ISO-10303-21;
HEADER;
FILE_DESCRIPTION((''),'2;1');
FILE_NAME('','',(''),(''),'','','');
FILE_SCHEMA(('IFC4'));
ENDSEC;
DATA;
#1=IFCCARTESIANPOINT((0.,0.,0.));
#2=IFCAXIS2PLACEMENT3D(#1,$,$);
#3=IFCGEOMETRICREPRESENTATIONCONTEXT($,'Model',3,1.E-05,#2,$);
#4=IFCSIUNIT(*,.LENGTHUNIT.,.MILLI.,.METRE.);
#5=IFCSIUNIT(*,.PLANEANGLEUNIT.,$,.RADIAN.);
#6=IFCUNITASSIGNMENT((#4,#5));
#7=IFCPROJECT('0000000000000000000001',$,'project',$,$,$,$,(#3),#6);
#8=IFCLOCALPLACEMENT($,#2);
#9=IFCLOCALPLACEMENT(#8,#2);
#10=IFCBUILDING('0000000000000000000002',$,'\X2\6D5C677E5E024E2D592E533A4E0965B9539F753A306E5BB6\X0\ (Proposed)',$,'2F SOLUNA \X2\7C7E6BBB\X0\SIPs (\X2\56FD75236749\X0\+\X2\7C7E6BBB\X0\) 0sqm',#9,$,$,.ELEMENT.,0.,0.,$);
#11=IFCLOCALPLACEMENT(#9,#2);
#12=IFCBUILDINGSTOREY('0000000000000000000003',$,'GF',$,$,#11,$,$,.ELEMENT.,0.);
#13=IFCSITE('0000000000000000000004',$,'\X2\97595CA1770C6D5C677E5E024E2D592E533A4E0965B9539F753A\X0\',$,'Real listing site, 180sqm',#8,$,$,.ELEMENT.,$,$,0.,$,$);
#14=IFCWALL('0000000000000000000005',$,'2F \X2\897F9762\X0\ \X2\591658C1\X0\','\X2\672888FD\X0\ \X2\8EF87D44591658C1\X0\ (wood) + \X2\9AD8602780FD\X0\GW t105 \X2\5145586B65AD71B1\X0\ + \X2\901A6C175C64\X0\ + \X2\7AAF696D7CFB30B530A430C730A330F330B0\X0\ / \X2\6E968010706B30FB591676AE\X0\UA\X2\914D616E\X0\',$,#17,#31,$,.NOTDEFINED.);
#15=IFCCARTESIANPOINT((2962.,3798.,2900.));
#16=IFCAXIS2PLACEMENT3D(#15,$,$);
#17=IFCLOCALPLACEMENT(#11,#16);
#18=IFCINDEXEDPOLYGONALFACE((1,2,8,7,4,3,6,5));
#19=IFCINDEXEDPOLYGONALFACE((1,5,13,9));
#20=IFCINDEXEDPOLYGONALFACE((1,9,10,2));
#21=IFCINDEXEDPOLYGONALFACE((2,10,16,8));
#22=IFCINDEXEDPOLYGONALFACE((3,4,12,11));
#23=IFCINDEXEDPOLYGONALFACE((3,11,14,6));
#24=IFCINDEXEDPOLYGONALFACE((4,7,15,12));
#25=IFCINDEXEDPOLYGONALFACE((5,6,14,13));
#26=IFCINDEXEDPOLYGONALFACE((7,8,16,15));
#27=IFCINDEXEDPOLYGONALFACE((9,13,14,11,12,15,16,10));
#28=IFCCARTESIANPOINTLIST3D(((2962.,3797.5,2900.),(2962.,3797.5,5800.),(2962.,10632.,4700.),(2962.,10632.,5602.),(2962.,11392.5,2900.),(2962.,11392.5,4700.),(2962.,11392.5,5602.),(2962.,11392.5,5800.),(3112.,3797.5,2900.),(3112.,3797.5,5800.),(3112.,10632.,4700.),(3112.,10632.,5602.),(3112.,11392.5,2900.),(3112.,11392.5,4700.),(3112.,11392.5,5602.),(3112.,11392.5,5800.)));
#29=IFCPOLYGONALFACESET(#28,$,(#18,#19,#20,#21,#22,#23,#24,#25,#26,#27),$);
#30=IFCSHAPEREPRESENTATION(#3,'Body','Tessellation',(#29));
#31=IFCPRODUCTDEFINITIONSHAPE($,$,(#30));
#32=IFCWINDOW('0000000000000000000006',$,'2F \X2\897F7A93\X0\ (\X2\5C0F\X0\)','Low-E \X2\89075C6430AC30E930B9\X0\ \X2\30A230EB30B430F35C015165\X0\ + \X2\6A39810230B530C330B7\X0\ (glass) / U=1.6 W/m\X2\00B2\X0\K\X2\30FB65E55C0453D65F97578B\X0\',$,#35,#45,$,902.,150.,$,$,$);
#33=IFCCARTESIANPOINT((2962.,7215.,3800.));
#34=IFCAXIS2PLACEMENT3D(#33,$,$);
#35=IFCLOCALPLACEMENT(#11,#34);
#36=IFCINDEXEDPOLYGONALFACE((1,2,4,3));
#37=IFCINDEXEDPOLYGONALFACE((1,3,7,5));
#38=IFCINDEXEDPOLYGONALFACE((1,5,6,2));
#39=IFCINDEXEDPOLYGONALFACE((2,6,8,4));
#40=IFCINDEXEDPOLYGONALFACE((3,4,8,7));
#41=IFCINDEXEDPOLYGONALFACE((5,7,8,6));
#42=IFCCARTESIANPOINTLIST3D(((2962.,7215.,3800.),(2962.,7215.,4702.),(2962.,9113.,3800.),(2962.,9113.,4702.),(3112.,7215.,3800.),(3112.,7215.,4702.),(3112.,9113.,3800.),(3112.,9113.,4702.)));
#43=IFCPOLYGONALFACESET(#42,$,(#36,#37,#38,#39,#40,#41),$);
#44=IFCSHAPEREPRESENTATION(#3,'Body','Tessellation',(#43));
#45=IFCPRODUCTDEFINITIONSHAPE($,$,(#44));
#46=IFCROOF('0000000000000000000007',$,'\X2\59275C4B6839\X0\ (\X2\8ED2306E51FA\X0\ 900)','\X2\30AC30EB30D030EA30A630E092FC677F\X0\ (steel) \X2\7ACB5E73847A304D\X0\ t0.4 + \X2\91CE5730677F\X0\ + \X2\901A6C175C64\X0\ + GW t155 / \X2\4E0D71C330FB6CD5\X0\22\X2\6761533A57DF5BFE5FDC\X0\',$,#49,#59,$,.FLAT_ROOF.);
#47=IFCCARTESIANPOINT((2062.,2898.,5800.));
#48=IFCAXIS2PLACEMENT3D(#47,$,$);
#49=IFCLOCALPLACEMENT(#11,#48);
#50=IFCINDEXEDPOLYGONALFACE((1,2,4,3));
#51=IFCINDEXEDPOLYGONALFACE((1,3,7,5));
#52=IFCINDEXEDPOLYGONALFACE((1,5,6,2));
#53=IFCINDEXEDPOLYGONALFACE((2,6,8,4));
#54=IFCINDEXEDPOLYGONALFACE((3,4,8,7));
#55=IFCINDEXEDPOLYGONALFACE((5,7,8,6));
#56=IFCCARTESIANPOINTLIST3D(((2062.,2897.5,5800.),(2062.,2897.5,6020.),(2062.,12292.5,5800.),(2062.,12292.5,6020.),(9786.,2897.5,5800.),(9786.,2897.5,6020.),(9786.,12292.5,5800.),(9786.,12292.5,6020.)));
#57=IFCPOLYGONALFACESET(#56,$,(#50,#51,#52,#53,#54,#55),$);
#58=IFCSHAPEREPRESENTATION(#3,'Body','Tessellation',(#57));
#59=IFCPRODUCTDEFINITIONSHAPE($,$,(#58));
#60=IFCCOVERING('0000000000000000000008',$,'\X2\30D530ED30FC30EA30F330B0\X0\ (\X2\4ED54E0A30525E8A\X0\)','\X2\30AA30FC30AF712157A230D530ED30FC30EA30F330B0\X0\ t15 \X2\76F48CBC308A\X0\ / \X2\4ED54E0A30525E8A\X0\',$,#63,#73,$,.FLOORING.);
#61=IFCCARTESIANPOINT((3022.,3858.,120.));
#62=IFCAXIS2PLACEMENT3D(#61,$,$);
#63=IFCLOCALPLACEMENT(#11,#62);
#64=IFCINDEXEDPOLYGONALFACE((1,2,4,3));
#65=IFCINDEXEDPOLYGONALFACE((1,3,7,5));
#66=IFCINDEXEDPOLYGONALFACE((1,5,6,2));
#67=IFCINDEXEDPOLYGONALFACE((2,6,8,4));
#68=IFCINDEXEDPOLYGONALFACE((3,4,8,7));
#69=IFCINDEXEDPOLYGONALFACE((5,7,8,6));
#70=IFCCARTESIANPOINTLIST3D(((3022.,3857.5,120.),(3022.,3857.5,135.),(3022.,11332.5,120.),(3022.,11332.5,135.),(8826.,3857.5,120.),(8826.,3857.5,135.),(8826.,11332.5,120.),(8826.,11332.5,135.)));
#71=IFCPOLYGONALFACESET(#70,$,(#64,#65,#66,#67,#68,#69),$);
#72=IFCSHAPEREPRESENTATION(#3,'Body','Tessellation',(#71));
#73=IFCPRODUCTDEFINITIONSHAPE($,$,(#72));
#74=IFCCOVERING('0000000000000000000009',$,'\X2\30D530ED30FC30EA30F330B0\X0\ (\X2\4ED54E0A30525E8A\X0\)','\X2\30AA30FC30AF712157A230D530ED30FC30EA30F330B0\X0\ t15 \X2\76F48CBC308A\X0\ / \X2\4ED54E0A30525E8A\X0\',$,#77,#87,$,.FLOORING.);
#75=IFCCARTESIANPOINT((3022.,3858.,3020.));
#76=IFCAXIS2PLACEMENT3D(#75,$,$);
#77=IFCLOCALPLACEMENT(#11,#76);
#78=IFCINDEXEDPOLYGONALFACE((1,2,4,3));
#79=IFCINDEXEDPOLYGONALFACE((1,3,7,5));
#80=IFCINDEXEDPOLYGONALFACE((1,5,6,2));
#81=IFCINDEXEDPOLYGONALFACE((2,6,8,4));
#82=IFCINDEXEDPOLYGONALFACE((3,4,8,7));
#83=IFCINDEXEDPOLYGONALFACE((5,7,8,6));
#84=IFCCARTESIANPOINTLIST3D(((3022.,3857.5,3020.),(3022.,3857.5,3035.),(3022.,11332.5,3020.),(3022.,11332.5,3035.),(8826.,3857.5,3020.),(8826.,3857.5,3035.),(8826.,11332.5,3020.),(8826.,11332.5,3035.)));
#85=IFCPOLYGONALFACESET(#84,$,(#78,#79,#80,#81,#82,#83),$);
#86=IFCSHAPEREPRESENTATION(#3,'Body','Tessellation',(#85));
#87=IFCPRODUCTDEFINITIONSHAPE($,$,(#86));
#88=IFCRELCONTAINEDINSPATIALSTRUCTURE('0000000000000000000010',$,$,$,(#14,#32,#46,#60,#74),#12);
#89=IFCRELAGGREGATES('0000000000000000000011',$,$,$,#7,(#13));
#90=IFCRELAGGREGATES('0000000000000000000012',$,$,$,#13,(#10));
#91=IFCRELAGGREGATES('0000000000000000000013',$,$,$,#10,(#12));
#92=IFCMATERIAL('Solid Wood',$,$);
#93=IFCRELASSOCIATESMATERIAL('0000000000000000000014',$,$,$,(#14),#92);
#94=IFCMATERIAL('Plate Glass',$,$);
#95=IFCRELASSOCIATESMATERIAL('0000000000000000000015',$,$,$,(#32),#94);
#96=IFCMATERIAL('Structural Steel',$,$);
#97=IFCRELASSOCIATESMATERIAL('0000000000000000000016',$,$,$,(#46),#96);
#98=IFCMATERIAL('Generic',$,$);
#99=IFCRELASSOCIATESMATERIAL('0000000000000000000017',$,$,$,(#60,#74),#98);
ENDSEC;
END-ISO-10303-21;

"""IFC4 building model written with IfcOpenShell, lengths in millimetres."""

from ifc_helpers import new_model, si_unit, frame, frame_2d, origin, place, context, project, spatial, rectangle, extrude, material, element, fill, save


model = new_model("IFC4")

# Units and contexts
model_context = context("Model", 3, precision=1e-05, world=origin())
ifc_project = project(units=[si_unit("LENGTHUNIT", "METRE", prefix="MILLI"), si_unit("PLANEANGLEUNIT", "RADIAN")], contexts=[model_context])

# Site, building, storey
site_placement = place(None, origin())
site = spatial("IfcSite", under=ifc_project, at=site_placement, Name="静岡県浜松市中央区三方原町", ObjectType="Real listing site, 180sqm", CompositionType="ELEMENT", RefElevation=0.0)
building_placement = place(site_placement, origin())
building = spatial("IfcBuilding", under=site, at=building_placement, Name="浜松市中央区三方原町の家 (Proposed)", ObjectType="2F SOLUNA 籾殻SIPs (国産杉+籾殻) 0sqm", CompositionType="ELEMENT", ElevationOfRefHeight=0.0, ElevationOfTerrain=0.0)
storey_placement = place(building_placement, origin())
storey = spatial("IfcBuildingStorey", under=building, at=storey_placement, Name="GF", CompositionType="ELEMENT", Elevation=0.0)

# Shared definitions
ifc_material_1 = material(Name="Solid Wood")

# Shared definitions
ifc_material_2 = material(Name="Plate Glass")

# Wall, opening, window
wall_1_placement = place(storey_placement, frame((2962.0, 3798.0, 2900.0)))
wall_1 = element("IfcWall", 1, at=wall_1_placement, inside=storey, material=ifc_material_1, Name="2F 西面 外壁", Description="木製 軸組外壁 (wood) + 高性能GW t105 充填断熱 + 通気層 + 窯業系サイディング / 準耐火・外皮UA配慮", PredefinedType="NOTDEFINED", context=model_context, shape_type="SweptSolid", body=[
    extrude(rectangle(XDim=150.0, YDim=7595.0, at=frame_2d((75.0, 3797.0))), frame((2962.0, 3798.0, 2900.0)), (0.0, 0.0, 1.0), 2900.0),
])
opening_1_placement = place(storey_placement, frame((2962.0, 7215.0, 3800.0)))
opening_1 = element("IfcOpeningElement", 2, at=opening_1_placement, cuts=wall_1, PredefinedType="NOTDEFINED", context=model_context, shape_type="SweptSolid", body=[
    extrude(rectangle(XDim=150.0, YDim=1898.0, at=frame_2d((75.0, 949.0))), frame((2962.0, 7215.0, 3800.0)), (0.0, 0.0, 1.0), 902.0),
])
window_1_placement = place(storey_placement, frame((2962.0, 7215.0, 3800.0)))
window_1 = element("IfcWindow", 3, at=window_1_placement, inside=storey, material=ifc_material_2, Name="2F 西窓 (小)", Description="Low-E 複層ガラス アルゴン封入 + 樹脂サッシ (glass) / U=1.6 W/m²K・日射取得型", OverallHeight=902.0, OverallWidth=150.0, context=model_context, shape_type="SweptSolid", body=[
    extrude(rectangle(XDim=150.0, YDim=1898.0, at=frame_2d((75.0, 949.0))), frame((2962.0, 7215.0, 3800.0)), (0.0, 0.0, 1.0), 902.0),
])
fill(opening_1, window_1)

# Roof
ifc_material_3 = material(Name="Structural Steel")
roof_placement = place(storey_placement, frame((2062.0, 2898.0, 5800.0)))
element("IfcRoof", 4, at=roof_placement, inside=storey, material=ifc_material_3, Name="大屋根 (軒の出 900)", Description="ガルバリウム鋼板 (steel) 立平葺き t0.4 + 野地板 + 通気層 + GW t155 / 不燃・法22条区域対応", PredefinedType="FLAT_ROOF", context=model_context, shape_type="SweptSolid", body=[
    extrude(rectangle(XDim=7724.0, YDim=9395.0, at=frame_2d((3862.0, 4697.0))), frame((2062.0, 2898.0, 5800.0)), (0.0, 0.0, 1.0), 220.0),
])

# Coverings
ifc_material_4 = material(Name="Generic")
covering_1_placement = place(storey_placement, frame((3022.0, 3858.0, 120.0)))
element("IfcCovering", 5, at=covering_1_placement, inside=storey, material=ifc_material_4, Name="フローリング (仕上げ床)", Description="オーク無垢フローリング t15 直貼り / 仕上げ床", PredefinedType="FLOORING", context=model_context, shape_type="SweptSolid", body=[
    extrude(rectangle(XDim=5804.0, YDim=7475.0, at=frame_2d((2902.0, 3737.0))), frame((3022.0, 3858.0, 120.0)), (0.0, 0.0, 1.0), 15.0),
])
covering_2_placement = place(storey_placement, frame((3022.0, 3858.0, 3020.0)))
element("IfcCovering", 6, at=covering_2_placement, inside=storey, material=ifc_material_4, Name="フローリング (仕上げ床)", Description="オーク無垢フローリング t15 直貼り / 仕上げ床", PredefinedType="FLOORING", context=model_context, shape_type="SweptSolid", body=[
    extrude(rectangle(XDim=5804.0, YDim=7475.0, at=frame_2d((2902.0, 3737.0))), frame((3022.0, 3858.0, 3020.0)), (0.0, 0.0, 1.0), 15.0),
])

save(model, "model.ifc")
